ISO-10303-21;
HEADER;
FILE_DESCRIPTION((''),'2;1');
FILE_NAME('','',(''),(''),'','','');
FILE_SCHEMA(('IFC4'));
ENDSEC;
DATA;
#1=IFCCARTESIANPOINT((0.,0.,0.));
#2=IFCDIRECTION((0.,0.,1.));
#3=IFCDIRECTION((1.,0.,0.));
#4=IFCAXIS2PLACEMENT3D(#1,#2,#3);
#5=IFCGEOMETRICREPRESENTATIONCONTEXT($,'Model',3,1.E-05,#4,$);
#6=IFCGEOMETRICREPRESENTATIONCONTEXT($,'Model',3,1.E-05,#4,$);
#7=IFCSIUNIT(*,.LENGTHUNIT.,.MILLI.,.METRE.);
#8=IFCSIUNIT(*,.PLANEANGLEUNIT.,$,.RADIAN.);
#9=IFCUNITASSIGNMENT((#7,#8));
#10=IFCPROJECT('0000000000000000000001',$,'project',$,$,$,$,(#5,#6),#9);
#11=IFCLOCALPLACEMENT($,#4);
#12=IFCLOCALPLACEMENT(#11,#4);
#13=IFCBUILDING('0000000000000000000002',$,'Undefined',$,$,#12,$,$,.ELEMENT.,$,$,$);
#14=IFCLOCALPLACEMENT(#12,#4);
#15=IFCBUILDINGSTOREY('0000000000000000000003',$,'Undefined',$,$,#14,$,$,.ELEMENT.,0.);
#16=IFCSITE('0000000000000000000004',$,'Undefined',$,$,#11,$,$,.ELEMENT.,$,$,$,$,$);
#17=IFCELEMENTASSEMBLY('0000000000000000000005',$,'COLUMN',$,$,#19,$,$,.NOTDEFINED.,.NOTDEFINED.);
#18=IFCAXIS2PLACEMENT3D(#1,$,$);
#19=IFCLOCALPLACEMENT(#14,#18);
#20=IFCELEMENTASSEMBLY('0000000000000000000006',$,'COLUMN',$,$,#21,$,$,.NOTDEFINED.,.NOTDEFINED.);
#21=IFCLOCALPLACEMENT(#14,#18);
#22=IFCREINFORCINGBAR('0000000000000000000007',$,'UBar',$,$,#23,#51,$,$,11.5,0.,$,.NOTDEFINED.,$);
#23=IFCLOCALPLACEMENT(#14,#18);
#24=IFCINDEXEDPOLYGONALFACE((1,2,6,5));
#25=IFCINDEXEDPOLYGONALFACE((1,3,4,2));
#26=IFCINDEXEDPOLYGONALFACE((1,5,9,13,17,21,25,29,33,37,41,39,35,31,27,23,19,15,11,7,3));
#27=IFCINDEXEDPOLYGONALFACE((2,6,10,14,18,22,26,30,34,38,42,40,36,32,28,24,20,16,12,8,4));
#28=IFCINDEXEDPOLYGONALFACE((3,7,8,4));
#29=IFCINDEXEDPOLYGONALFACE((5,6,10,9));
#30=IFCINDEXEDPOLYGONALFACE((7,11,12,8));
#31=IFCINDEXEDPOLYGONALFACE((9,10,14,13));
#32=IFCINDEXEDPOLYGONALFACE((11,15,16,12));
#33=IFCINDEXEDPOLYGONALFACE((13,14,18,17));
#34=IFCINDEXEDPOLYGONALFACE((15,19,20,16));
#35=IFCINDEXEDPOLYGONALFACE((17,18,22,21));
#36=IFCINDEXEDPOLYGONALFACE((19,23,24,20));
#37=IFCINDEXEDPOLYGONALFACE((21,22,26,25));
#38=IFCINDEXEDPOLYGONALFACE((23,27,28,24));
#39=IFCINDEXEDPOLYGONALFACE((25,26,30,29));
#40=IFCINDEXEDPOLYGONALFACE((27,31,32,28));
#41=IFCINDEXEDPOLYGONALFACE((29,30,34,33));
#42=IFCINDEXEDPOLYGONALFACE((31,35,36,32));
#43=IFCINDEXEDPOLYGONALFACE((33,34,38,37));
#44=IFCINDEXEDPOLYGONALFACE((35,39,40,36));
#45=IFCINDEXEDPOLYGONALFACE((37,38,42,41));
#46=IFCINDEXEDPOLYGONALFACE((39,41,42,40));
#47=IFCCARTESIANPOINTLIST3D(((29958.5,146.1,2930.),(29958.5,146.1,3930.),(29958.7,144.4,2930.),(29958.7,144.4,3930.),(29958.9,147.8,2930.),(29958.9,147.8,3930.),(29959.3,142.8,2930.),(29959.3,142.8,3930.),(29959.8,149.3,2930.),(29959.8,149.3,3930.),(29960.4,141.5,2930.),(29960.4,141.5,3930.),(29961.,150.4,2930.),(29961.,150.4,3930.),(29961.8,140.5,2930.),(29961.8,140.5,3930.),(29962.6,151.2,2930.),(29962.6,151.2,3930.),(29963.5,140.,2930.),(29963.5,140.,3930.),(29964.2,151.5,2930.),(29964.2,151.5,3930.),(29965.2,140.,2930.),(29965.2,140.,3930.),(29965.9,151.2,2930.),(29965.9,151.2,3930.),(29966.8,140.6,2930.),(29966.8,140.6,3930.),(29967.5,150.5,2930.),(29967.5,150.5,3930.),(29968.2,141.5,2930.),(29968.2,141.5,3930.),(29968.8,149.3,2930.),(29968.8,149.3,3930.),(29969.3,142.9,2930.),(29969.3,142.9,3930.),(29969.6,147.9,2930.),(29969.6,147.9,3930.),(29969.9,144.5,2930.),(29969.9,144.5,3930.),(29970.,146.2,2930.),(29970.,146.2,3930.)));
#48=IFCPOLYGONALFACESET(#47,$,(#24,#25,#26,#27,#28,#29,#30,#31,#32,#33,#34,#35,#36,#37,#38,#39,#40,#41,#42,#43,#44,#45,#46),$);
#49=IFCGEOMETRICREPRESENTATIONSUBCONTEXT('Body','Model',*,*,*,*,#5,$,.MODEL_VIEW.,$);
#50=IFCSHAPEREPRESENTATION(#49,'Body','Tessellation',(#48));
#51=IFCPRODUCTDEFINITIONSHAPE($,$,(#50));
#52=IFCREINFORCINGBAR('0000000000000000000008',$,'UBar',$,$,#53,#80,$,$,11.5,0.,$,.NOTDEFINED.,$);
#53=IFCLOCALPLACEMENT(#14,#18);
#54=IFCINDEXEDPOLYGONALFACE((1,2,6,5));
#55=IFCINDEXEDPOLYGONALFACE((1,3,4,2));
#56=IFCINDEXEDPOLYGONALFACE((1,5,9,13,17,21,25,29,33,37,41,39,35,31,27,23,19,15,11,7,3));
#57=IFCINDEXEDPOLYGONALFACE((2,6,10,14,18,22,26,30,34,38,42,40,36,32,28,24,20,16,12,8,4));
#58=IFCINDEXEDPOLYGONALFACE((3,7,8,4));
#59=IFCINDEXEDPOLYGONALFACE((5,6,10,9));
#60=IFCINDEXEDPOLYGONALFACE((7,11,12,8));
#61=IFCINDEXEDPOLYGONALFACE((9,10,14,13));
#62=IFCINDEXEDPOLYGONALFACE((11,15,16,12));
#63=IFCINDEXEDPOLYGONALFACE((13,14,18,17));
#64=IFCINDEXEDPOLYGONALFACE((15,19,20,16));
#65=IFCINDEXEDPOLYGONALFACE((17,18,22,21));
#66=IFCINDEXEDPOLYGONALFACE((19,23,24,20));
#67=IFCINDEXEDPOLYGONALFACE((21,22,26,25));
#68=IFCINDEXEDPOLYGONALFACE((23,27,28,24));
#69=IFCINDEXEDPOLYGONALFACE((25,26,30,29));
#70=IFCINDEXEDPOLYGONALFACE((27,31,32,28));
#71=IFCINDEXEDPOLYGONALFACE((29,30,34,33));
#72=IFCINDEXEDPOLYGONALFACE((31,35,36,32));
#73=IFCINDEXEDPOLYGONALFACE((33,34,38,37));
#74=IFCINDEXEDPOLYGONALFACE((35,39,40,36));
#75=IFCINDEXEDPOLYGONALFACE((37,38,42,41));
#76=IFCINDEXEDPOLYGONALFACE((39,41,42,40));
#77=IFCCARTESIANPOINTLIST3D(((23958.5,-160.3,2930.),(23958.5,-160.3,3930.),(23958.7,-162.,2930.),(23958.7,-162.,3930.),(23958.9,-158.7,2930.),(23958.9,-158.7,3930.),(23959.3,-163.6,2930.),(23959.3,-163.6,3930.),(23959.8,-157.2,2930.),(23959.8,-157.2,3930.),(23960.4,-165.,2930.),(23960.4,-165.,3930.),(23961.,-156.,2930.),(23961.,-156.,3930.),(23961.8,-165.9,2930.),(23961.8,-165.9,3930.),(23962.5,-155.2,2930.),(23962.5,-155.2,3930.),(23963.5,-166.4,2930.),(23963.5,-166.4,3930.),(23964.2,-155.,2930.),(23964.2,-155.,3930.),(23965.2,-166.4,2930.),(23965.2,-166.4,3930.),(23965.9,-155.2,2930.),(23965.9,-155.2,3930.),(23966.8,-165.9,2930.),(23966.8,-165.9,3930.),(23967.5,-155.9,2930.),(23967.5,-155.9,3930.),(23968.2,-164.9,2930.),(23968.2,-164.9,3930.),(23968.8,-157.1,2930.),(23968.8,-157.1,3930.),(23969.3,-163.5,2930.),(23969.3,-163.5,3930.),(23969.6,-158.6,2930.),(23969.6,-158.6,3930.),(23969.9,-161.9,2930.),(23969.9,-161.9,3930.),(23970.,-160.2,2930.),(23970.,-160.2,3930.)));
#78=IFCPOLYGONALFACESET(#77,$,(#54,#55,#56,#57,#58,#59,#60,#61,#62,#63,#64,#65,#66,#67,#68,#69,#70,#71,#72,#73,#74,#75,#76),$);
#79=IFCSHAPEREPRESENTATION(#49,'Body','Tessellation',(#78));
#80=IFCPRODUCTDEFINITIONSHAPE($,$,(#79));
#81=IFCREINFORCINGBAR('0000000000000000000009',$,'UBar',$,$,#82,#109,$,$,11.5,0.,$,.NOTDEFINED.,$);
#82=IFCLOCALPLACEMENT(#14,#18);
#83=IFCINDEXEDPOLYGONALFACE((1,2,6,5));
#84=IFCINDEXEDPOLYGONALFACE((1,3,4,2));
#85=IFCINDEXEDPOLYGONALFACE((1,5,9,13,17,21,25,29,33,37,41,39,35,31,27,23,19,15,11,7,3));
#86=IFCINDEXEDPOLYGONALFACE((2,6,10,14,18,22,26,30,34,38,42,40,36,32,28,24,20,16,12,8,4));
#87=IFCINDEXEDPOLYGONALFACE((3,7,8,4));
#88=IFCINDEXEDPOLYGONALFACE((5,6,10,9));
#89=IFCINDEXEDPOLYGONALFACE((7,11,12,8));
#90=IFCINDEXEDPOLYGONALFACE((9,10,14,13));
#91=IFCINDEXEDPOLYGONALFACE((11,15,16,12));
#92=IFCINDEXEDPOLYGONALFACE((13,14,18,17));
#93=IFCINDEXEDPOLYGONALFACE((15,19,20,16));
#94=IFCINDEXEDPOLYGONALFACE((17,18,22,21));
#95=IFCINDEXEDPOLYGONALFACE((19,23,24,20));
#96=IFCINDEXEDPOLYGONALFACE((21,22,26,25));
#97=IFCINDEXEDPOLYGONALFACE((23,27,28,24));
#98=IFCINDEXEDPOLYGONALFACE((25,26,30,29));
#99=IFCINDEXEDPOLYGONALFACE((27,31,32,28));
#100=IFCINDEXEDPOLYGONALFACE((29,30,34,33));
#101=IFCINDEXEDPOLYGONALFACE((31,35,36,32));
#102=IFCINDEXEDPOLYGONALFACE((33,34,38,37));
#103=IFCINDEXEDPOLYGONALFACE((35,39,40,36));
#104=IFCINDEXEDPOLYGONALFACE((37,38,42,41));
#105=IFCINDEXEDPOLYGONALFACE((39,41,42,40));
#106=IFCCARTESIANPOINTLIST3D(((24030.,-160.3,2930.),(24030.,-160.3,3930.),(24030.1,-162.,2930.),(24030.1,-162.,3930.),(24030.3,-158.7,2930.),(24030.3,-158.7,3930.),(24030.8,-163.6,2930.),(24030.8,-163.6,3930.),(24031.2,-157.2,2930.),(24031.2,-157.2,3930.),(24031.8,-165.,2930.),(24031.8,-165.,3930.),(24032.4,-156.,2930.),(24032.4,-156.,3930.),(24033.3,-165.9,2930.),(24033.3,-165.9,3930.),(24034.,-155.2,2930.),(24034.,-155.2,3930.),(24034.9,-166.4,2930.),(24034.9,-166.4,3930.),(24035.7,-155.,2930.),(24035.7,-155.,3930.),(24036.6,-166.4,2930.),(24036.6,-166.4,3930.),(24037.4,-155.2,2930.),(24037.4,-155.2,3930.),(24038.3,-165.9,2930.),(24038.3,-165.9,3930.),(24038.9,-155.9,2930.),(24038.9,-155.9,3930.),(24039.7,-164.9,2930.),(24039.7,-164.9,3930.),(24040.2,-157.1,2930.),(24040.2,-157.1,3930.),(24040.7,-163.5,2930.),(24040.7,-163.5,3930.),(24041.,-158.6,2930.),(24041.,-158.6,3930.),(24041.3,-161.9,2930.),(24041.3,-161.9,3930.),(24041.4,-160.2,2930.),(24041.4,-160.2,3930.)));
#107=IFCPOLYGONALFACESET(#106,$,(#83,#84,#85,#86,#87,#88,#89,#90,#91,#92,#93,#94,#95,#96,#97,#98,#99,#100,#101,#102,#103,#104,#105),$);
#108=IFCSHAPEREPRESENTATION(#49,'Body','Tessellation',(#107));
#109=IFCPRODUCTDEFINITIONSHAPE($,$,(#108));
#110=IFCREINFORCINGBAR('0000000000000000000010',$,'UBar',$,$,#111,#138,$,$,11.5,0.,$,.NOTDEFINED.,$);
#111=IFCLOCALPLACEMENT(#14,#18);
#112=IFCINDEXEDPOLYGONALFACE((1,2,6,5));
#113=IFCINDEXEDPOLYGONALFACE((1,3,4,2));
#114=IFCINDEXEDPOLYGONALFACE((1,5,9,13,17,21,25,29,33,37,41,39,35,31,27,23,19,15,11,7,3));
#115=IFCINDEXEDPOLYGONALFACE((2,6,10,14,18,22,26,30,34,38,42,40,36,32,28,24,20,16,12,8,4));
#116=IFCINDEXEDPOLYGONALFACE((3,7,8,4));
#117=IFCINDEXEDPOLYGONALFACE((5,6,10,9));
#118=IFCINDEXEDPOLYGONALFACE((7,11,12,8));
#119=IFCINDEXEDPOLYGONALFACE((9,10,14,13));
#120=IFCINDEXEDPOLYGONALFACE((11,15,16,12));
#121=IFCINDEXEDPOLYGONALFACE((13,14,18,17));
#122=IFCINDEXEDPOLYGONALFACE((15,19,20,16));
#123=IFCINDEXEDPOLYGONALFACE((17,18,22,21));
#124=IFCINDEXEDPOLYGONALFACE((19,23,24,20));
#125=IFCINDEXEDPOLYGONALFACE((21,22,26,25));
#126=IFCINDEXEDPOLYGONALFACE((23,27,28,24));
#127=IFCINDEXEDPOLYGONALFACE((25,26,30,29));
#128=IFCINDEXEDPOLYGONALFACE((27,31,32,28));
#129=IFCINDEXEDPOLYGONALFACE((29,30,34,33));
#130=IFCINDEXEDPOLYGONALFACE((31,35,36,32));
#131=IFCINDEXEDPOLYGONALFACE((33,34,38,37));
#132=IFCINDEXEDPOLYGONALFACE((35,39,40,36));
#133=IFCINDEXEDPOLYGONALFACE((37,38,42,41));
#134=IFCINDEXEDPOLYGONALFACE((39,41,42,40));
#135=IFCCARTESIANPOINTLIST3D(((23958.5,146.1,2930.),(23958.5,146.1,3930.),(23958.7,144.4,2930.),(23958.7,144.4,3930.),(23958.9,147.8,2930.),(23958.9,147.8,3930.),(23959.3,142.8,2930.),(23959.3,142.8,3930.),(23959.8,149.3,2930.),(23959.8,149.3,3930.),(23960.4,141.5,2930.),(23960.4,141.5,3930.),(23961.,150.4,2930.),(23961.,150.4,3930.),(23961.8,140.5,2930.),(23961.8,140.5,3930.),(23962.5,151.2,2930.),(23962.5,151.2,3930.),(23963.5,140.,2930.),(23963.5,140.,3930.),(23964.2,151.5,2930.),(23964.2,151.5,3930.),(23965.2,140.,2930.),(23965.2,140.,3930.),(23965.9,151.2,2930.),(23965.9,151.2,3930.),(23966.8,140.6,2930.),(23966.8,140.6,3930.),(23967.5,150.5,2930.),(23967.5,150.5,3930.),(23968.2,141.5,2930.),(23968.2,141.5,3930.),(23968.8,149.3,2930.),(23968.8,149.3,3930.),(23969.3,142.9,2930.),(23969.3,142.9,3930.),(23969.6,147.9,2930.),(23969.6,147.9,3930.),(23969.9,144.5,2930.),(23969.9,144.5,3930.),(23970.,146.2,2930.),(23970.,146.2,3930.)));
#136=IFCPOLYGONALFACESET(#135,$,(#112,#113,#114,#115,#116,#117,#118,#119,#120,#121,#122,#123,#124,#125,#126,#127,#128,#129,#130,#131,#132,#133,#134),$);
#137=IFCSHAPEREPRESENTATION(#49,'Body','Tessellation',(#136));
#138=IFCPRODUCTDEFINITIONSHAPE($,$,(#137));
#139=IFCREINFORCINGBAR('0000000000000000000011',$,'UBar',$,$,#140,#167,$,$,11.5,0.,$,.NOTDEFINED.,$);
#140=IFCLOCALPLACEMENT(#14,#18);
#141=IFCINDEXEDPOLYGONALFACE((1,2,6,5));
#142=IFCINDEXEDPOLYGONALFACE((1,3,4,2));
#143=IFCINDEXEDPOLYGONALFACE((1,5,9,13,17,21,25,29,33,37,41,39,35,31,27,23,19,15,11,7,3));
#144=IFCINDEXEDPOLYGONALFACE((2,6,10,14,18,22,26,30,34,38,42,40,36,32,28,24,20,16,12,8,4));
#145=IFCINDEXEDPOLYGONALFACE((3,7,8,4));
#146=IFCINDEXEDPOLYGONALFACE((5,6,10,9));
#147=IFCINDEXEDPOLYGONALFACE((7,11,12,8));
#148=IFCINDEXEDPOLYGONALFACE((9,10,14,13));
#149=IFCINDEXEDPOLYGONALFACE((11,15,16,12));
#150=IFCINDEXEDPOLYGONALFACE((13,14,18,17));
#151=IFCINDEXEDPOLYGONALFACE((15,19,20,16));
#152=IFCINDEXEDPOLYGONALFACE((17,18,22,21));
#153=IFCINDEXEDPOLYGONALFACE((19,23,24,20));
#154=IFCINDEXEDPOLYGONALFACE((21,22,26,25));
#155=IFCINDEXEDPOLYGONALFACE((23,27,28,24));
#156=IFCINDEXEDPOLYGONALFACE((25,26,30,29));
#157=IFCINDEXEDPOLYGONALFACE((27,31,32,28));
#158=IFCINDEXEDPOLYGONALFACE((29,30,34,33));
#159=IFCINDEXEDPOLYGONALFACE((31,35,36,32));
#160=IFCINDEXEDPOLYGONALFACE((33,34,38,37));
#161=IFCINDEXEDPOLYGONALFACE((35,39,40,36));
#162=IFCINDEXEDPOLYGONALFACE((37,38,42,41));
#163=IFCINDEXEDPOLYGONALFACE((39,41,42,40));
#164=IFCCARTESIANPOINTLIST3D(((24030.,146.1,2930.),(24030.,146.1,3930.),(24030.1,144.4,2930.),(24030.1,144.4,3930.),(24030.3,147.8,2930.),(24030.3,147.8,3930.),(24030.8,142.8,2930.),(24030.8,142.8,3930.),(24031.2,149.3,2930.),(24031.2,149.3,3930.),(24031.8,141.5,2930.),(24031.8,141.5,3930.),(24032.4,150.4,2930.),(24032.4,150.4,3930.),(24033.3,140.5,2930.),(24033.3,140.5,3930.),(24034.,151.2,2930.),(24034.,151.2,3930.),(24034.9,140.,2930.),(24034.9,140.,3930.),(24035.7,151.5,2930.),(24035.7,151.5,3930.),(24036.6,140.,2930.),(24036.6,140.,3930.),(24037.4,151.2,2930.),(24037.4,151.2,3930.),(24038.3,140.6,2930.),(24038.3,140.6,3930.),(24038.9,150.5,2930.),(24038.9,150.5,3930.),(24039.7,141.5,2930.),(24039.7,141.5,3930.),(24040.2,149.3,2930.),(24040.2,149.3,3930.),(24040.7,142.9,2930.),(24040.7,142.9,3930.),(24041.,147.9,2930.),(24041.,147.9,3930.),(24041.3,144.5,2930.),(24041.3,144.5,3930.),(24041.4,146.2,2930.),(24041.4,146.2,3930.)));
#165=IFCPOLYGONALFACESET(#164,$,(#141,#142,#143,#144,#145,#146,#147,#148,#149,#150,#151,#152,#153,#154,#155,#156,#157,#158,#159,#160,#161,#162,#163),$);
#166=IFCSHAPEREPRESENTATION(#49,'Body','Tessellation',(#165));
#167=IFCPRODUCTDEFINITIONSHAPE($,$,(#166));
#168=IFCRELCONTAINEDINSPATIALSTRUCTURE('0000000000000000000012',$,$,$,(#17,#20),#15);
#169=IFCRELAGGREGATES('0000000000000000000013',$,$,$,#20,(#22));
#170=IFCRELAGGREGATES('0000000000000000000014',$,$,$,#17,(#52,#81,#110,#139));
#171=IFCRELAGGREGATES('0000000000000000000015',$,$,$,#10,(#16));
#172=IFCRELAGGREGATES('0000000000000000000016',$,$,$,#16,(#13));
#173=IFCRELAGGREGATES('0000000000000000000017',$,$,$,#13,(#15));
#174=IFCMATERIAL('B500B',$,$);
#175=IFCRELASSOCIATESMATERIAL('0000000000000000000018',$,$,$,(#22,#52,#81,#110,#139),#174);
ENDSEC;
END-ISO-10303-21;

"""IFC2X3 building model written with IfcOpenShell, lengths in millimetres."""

from ifc_helpers import new_model, entity, si_unit, frame, origin_with_axes, place, context, subcontext, project, spatial, source, transform, mapped, material, element, aggregate, save


model = new_model("IFC2X3")

# Units and contexts
model_context_1 = context("Model", 3, precision=1e-05, world=origin_with_axes())
model_context_2 = context("Model", 3, precision=1e-05, world=origin_with_axes())
body_context = subcontext(model_context_1, "Body", "Model", "MODEL_VIEW")
ifc_project = project(units=[si_unit("LENGTHUNIT", "METRE", prefix="MILLI"), si_unit("PLANEANGLEUNIT", "RADIAN")], contexts=[model_context_1, model_context_2])

# Site, building, storey
site_placement = place(None, origin_with_axes())
site = spatial("IfcSite", under=ifc_project, at=site_placement, Name="Undefined", CompositionType="ELEMENT")
building_placement = place(site_placement, origin_with_axes())
building = spatial("IfcBuilding", under=site, at=building_placement, Name="Undefined", CompositionType="ELEMENT")
storey_placement = place(building_placement, origin_with_axes())
storey = spatial("IfcBuildingStorey", under=building, at=storey_placement, Name="Undefined", CompositionType="ELEMENT", Elevation=0.0)

# Element assembly
assembly_1_placement = place(storey_placement, origin_with_axes())
assembly_1 = element("IfcElementAssembly", 1, at=assembly_1_placement, inside=storey, Name="COLUMN", AssemblyPlace="NOTDEFINED", PredefinedType="NOTDEFINED")

# Element assembly
assembly_2_placement = place(storey_placement, origin_with_axes())
assembly_2 = element("IfcElementAssembly", 2, at=assembly_2_placement, inside=storey, Name="COLUMN", AssemblyPlace="NOTDEFINED", PredefinedType="NOTDEFINED")

# Reinforcing bars
ifc_material_1 = material(Name="B500B")
shared_shape_1 = source(origin_with_axes(), body_context, "Body", "AdvancedSweptSolid", [
    entity("IfcSweptDiskSolid", entity("IfcTrimmedCurve", entity("IfcLine", entity("IfcCartesianPoint", [0.0, 0.0, 0.0]), entity("IfcVector", entity("IfcDirection", [1.0, 0.0, 0.0]), 1.0)), [entity("IfcParameterValue", 0.0)], [entity("IfcParameterValue", 1000.0)], True, "PARAMETER"), 5.8, None, 0.0, 1000.0),
])
reinforcing_bar_1_placement = place(assembly_2_placement, frame((29964.3, 145.7, 3930.0), z_axis=(-0.006667, 0.999978, 0.0), x_axis=(0.0, 0.0, -1.0)))
reinforcing_bar_1 = element("IfcReinforcingBar", 3, at=reinforcing_bar_1_placement, material=ifc_material_1, Name="UBar", BarRole="NOTDEFINED", CrossSectionArea=0.0, NominalDiameter=11.5, context=body_context, shape_type="MappedRepresentation", body=[
    mapped(shared_shape_1, transform((0.0, 0.0, 0.0))),
])
aggregate(assembly_2, [reinforcing_bar_1])
shared_shape_2 = source(origin_with_axes(), body_context, "Body", "AdvancedSweptSolid", [
    entity("IfcSweptDiskSolid", entity("IfcTrimmedCurve", entity("IfcLine", entity("IfcCartesianPoint", [0.0, 0.0, 0.0]), entity("IfcVector", entity("IfcDirection", [1.0, 0.0, 0.0]), 1.0)), [entity("IfcParameterValue", 0.0)], [entity("IfcParameterValue", 1000.0)], True, "PARAMETER"), 5.8, None, 0.0, 1000.0),
])
reinforcing_bar_2_placement = place(assembly_1_placement, frame((23964.3, -160.7, 3930.0), z_axis=(-0.008333, 0.999965, 0.0), x_axis=(0.0, 0.0, -1.0)))
reinforcing_bar_2 = element("IfcReinforcingBar", 4, at=reinforcing_bar_2_placement, material=ifc_material_1, Name="UBar", BarRole="NOTDEFINED", CrossSectionArea=0.0, NominalDiameter=11.5, context=body_context, shape_type="MappedRepresentation", body=[
    mapped(shared_shape_2, transform((0.0, 0.0, 0.0))),
])
shared_shape_3 = source(origin_with_axes(), body_context, "Body", "AdvancedSweptSolid", [
    entity("IfcSweptDiskSolid", entity("IfcTrimmedCurve", entity("IfcLine", entity("IfcCartesianPoint", [0.0, 0.0, 0.0]), entity("IfcVector", entity("IfcDirection", [1.0, 0.0, 0.0]), 1.0)), [entity("IfcParameterValue", 0.0)], [entity("IfcParameterValue", 1000.0)], True, "PARAMETER"), 5.8, None, 0.0, 1000.0),
])
reinforcing_bar_3_placement = place(assembly_1_placement, frame((24035.7, -160.7, 3930.0), z_axis=(-0.008333, 0.999965, 0.0), x_axis=(0.0, 0.0, -1.0)))
reinforcing_bar_3 = element("IfcReinforcingBar", 5, at=reinforcing_bar_3_placement, material=ifc_material_1, Name="UBar", BarRole="NOTDEFINED", CrossSectionArea=0.0, NominalDiameter=11.5, context=body_context, shape_type="MappedRepresentation", body=[
    mapped(shared_shape_3, transform((0.0, 0.0, 0.0))),
])
shared_shape_4 = source(origin_with_axes(), body_context, "Body", "AdvancedSweptSolid", [
    entity("IfcSweptDiskSolid", entity("IfcTrimmedCurve", entity("IfcLine", entity("IfcCartesianPoint", [0.0, 0.0, 0.0]), entity("IfcVector", entity("IfcDirection", [1.0, 0.0, 0.0]), 1.0)), [entity("IfcParameterValue", 0.0)], [entity("IfcParameterValue", 1000.0)], True, "PARAMETER"), 5.8, None, 0.0, 1000.0),
])
reinforcing_bar_4_placement = place(assembly_1_placement, frame((23964.3, 145.7, 3930.0), z_axis=(-0.008333, 0.999965, 0.0), x_axis=(0.0, 0.0, -1.0)))
reinforcing_bar_4 = element("IfcReinforcingBar", 6, at=reinforcing_bar_4_placement, material=ifc_material_1, Name="UBar", BarRole="NOTDEFINED", CrossSectionArea=0.0, NominalDiameter=11.5, context=body_context, shape_type="MappedRepresentation", body=[
    mapped(shared_shape_4, transform((0.0, 0.0, 0.0))),
])
shared_shape_5 = source(origin_with_axes(), body_context, "Body", "AdvancedSweptSolid", [
    entity("IfcSweptDiskSolid", entity("IfcTrimmedCurve", entity("IfcLine", entity("IfcCartesianPoint", [0.0, 0.0, 0.0]), entity("IfcVector", entity("IfcDirection", [1.0, 0.0, 0.0]), 1.0)), [entity("IfcParameterValue", 0.0)], [entity("IfcParameterValue", 1000.0)], True, "PARAMETER"), 5.8, None, 0.0, 1000.0),
])
reinforcing_bar_5_placement = place(assembly_1_placement, frame((24035.7, 145.7, 3930.0), z_axis=(-0.008333, 0.999965, 0.0), x_axis=(0.0, 0.0, -1.0)))
reinforcing_bar_5 = element("IfcReinforcingBar", 7, at=reinforcing_bar_5_placement, material=ifc_material_1, Name="UBar", BarRole="NOTDEFINED", CrossSectionArea=0.0, NominalDiameter=11.5, context=body_context, shape_type="MappedRepresentation", body=[
    mapped(shared_shape_5, transform((0.0, 0.0, 0.0))),
])
aggregate(assembly_1, [reinforcing_bar_2, reinforcing_bar_3, reinforcing_bar_4, reinforcing_bar_5])

save(model, "model.ifc")
